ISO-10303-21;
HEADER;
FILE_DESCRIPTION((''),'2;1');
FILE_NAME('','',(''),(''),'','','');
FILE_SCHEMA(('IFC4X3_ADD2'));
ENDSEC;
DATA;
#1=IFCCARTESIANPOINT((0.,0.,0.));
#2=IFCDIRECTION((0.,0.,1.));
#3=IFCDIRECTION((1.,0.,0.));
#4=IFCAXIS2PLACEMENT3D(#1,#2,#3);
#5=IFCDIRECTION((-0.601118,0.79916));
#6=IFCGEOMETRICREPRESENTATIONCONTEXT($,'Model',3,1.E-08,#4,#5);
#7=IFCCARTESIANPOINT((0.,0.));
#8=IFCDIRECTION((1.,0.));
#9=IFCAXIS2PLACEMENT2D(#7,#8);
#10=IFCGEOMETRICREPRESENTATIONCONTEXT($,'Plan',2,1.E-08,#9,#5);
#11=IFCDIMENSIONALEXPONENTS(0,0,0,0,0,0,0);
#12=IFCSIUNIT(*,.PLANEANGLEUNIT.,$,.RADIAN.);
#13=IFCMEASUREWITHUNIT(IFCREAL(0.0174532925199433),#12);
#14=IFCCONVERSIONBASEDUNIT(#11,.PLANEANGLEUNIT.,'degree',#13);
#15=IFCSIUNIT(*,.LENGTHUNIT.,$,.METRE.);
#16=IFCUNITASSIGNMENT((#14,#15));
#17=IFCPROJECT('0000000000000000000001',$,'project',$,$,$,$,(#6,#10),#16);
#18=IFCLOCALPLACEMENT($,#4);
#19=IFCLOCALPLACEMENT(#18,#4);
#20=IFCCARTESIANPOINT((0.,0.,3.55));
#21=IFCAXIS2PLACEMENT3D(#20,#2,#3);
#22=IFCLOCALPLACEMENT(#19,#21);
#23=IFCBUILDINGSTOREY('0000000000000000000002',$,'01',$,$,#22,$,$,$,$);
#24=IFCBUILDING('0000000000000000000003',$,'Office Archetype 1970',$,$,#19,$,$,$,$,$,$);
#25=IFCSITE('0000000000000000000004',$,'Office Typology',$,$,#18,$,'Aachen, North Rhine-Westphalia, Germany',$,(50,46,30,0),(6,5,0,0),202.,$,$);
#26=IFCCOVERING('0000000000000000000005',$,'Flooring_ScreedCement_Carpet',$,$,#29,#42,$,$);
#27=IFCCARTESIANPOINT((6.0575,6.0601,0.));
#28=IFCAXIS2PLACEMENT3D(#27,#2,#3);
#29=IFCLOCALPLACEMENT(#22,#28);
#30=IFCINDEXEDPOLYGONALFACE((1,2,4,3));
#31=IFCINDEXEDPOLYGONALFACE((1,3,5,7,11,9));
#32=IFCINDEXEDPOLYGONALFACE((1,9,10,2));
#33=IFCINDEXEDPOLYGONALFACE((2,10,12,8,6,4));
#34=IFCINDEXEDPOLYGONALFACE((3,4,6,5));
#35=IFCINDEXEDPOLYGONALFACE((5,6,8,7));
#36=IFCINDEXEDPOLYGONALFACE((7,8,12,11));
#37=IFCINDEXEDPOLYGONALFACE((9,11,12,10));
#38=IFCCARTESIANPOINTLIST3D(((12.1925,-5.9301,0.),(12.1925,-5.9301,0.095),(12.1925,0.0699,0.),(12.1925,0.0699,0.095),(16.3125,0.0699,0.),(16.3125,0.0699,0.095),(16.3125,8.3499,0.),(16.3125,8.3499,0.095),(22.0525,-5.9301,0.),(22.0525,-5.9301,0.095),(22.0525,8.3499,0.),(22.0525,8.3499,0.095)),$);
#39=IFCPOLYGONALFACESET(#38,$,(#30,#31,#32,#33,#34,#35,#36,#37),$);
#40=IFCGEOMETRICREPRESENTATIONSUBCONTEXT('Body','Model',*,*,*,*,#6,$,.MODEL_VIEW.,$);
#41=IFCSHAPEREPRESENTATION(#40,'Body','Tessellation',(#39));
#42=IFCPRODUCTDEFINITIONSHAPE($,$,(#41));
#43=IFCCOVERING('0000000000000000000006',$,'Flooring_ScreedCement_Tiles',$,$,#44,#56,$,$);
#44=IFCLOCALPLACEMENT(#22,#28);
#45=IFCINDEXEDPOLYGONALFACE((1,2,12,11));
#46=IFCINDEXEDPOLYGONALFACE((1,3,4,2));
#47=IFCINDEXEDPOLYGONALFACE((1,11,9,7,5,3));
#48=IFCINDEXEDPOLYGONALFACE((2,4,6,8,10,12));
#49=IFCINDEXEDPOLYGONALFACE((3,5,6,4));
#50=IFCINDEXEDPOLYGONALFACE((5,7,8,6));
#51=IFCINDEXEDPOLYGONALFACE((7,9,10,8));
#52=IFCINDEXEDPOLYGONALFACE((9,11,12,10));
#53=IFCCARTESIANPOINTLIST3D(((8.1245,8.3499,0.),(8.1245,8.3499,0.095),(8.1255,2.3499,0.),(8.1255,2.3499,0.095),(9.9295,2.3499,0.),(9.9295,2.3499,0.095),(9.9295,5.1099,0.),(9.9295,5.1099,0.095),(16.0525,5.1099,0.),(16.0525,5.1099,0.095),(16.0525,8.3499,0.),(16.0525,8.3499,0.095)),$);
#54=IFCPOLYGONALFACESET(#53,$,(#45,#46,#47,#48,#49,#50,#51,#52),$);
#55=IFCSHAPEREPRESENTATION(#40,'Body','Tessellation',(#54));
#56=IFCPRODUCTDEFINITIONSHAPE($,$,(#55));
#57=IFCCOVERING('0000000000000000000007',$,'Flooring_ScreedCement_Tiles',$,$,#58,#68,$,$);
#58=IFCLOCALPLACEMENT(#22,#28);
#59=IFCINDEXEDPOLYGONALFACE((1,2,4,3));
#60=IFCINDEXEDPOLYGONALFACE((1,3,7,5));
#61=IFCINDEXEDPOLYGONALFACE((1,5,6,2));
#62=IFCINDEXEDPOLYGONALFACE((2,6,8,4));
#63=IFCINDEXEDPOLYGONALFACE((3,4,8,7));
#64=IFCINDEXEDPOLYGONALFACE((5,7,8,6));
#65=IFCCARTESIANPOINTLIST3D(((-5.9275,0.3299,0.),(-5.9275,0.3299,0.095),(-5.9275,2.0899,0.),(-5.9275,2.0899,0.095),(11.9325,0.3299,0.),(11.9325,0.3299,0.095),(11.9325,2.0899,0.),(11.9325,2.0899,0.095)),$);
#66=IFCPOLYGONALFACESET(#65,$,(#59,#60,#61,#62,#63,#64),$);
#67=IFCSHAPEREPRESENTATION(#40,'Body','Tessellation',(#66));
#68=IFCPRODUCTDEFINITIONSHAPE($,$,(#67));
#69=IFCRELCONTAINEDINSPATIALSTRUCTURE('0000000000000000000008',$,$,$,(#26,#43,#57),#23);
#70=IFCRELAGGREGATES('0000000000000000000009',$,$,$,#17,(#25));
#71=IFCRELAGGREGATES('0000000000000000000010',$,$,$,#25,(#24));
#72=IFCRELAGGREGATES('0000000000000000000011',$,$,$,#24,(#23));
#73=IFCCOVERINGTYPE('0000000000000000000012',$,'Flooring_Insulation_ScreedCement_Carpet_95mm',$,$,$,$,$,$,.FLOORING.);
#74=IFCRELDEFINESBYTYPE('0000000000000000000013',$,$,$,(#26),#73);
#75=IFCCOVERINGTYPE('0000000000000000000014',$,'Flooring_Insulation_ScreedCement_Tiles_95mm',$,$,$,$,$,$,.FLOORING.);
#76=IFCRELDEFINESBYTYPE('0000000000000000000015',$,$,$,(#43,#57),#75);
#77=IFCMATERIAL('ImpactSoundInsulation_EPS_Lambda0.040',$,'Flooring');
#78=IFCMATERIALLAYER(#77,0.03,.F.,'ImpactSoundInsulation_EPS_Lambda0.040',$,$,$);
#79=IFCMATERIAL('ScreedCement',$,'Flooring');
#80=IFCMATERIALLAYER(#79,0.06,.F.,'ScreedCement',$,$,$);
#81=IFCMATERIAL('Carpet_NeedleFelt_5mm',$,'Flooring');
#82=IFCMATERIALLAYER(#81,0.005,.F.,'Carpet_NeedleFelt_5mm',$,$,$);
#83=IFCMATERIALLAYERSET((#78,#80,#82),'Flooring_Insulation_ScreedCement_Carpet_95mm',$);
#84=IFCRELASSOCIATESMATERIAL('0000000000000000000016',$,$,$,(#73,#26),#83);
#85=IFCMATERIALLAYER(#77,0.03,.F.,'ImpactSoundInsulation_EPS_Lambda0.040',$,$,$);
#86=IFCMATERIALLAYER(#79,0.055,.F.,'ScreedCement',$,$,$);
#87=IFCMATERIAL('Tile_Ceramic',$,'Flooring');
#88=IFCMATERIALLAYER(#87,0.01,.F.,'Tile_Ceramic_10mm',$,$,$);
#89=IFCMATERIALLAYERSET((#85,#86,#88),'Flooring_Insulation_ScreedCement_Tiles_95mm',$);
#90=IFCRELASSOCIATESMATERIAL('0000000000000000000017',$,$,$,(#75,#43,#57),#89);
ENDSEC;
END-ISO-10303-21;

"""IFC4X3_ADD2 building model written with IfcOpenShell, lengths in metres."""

from ifc_helpers import new_model, entity, si_unit, converted_unit, direction, frame, origin_with_axes, origin_2d_with_axis, place, context, subcontext, project, spatial, line, indexed_curve, outline, extrude, material, layer, layer_set, layer_usage, type_object, element, save


model = new_model("IFC4X3_ADD2")

# Units and contexts
model_context = context("Model", 3, precision=1e-08, world=origin_with_axes(), true_north=direction((-0.601118, 0.79916)))
plan_context = context("Plan", 2, precision=1e-08, world=origin_2d_with_axis(), true_north=direction((-0.601118, 0.79916)))
body_context = subcontext(model_context, "Body", "Model", "MODEL_VIEW")
ifc_project = project(units=[converted_unit("PLANEANGLEUNIT", "degree", entity("IfcReal", 0.0174532925199433), si_unit("PLANEANGLEUNIT", "RADIAN"), dimensions=[0, 0, 0, 0, 0, 0, 0]), si_unit("LENGTHUNIT", "METRE")], contexts=[model_context, plan_context])

# Site, building, storey
site_placement = place(None, origin_with_axes())
site = spatial("IfcSite", under=ifc_project, at=site_placement, Name="Office Typology", LongName="Aachen, North Rhine-Westphalia, Germany", RefLatitude=(50, 46, 30, 0), RefLongitude=(6, 5, 0, 0), RefElevation=202.0)
building_placement = place(site_placement, origin_with_axes())
building = spatial("IfcBuilding", under=site, at=building_placement, Name="Office Archetype 1970")
storey_placement = place(building_placement, frame((0.0, 0.0, 3.55), z_axis=(0.0, 0.0, 1.0), x_axis=(1.0, 0.0, 0.0)))
storey = spatial("IfcBuildingStorey", under=building, at=storey_placement, Name="01")

# Coverings
ifc_material_1 = material(Name="ImpactSoundInsulation_EPS_Lambda0.040", Category="Flooring")
ifc_layer_1 = layer(ifc_material_1, 0.03, ventilated=False, Name="ImpactSoundInsulation_EPS_Lambda0.040")
ifc_material_2 = material(Name="ScreedCement", Category="Flooring")
ifc_layer_2 = layer(ifc_material_2, 0.06, ventilated=False, Name="ScreedCement")
ifc_material_3 = material(Name="Carpet_NeedleFelt_5mm", Category="Flooring")
ifc_layer_3 = layer(ifc_material_3, 0.005, ventilated=False, Name="Carpet_NeedleFelt_5mm")
ifc_layer_set_1 = layer_set([ifc_layer_1, ifc_layer_2, ifc_layer_3], Name="Flooring_Insulation_ScreedCement_Carpet_95mm")
ifc_layer_usage_1 = layer_usage(ifc_layer_set_1, "AXIS3", "POSITIVE", 0.0)
covering_type_1 = type_object("IfcCoveringType", Name="Flooring_Insulation_ScreedCement_Carpet_95mm", PredefinedType="FLOORING", material=ifc_layer_set_1)
covering_1_placement = place(storey_placement, frame((6.0575, 6.0601, 0.0), z_axis=(0.0, 0.0, 1.0), x_axis=(1.0, 0.0, 0.0)))
element("IfcCovering", 1, at=covering_1_placement, inside=storey, type_object=covering_type_1, material=ifc_layer_usage_1, Name="Flooring_ScreedCement_Carpet", context=body_context, shape_type="SweptSolid", body=[
    extrude(outline(indexed_curve([(16.3125, 8.3499), (22.0525, 8.3499), (22.0525, -5.9301), (12.1925, -5.9301), (12.1925, 0.0699), (16.3125, 0.0699)], segments=[line(1, 2, 3, 4, 5, 6, 1)])), origin_with_axes(), (0.0, 0.0, 1.0), 0.095),
])
ifc_layer_4 = layer(ifc_material_1, 0.03, ventilated=False, Name="ImpactSoundInsulation_EPS_Lambda0.040")
ifc_layer_5 = layer(ifc_material_2, 0.055, ventilated=False, Name="ScreedCement")
ifc_material_4 = material(Name="Tile_Ceramic", Category="Flooring")
ifc_layer_6 = layer(ifc_material_4, 0.01, ventilated=False, Name="Tile_Ceramic_10mm")
ifc_layer_set_2 = layer_set([ifc_layer_4, ifc_layer_5, ifc_layer_6], Name="Flooring_Insulation_ScreedCement_Tiles_95mm")
ifc_layer_usage_2 = layer_usage(ifc_layer_set_2, "AXIS3", "POSITIVE", 0.0)
covering_type_2 = type_object("IfcCoveringType", Name="Flooring_Insulation_ScreedCement_Tiles_95mm", PredefinedType="FLOORING", material=ifc_layer_set_2)
covering_2_placement = place(storey_placement, frame((6.0575, 6.0601, 0.0), z_axis=(0.0, 0.0, 1.0), x_axis=(1.0, 0.0, 0.0)))
element("IfcCovering", 2, at=covering_2_placement, inside=storey, type_object=covering_type_2, material=ifc_layer_usage_2, Name="Flooring_ScreedCement_Tiles", context=body_context, shape_type="SweptSolid", body=[
    extrude(outline(indexed_curve([(9.9295, 2.3499), (8.1255, 2.3499), (8.1245, 8.3499), (16.0525, 8.3499), (16.0525, 5.1099), (9.9295, 5.1099)], segments=[line(1, 2, 3, 4, 5, 6, 1)])), None, (0.0, 0.0, 1.0), 0.095),
])
ifc_layer_usage_3 = layer_usage(ifc_layer_set_2, "AXIS3", "POSITIVE", 0.0)
covering_3_placement = place(storey_placement, frame((6.0575, 6.0601, 0.0), z_axis=(0.0, 0.0, 1.0), x_axis=(1.0, 0.0, 0.0)))
element("IfcCovering", 3, at=covering_3_placement, inside=storey, type_object=covering_type_2, material=ifc_layer_usage_3, Name="Flooring_ScreedCement_Tiles", context=body_context, shape_type="SweptSolid", body=[
    extrude(outline(indexed_curve([(-5.9275, 0.3299), (-5.9275, 2.0899), (11.9325, 2.0899), (11.9325, 0.3299)], segments=[line(1, 2, 3, 4, 1)])), None, (0.0, 0.0, 1.0), 0.095),
])

save(model, "model.ifc")
